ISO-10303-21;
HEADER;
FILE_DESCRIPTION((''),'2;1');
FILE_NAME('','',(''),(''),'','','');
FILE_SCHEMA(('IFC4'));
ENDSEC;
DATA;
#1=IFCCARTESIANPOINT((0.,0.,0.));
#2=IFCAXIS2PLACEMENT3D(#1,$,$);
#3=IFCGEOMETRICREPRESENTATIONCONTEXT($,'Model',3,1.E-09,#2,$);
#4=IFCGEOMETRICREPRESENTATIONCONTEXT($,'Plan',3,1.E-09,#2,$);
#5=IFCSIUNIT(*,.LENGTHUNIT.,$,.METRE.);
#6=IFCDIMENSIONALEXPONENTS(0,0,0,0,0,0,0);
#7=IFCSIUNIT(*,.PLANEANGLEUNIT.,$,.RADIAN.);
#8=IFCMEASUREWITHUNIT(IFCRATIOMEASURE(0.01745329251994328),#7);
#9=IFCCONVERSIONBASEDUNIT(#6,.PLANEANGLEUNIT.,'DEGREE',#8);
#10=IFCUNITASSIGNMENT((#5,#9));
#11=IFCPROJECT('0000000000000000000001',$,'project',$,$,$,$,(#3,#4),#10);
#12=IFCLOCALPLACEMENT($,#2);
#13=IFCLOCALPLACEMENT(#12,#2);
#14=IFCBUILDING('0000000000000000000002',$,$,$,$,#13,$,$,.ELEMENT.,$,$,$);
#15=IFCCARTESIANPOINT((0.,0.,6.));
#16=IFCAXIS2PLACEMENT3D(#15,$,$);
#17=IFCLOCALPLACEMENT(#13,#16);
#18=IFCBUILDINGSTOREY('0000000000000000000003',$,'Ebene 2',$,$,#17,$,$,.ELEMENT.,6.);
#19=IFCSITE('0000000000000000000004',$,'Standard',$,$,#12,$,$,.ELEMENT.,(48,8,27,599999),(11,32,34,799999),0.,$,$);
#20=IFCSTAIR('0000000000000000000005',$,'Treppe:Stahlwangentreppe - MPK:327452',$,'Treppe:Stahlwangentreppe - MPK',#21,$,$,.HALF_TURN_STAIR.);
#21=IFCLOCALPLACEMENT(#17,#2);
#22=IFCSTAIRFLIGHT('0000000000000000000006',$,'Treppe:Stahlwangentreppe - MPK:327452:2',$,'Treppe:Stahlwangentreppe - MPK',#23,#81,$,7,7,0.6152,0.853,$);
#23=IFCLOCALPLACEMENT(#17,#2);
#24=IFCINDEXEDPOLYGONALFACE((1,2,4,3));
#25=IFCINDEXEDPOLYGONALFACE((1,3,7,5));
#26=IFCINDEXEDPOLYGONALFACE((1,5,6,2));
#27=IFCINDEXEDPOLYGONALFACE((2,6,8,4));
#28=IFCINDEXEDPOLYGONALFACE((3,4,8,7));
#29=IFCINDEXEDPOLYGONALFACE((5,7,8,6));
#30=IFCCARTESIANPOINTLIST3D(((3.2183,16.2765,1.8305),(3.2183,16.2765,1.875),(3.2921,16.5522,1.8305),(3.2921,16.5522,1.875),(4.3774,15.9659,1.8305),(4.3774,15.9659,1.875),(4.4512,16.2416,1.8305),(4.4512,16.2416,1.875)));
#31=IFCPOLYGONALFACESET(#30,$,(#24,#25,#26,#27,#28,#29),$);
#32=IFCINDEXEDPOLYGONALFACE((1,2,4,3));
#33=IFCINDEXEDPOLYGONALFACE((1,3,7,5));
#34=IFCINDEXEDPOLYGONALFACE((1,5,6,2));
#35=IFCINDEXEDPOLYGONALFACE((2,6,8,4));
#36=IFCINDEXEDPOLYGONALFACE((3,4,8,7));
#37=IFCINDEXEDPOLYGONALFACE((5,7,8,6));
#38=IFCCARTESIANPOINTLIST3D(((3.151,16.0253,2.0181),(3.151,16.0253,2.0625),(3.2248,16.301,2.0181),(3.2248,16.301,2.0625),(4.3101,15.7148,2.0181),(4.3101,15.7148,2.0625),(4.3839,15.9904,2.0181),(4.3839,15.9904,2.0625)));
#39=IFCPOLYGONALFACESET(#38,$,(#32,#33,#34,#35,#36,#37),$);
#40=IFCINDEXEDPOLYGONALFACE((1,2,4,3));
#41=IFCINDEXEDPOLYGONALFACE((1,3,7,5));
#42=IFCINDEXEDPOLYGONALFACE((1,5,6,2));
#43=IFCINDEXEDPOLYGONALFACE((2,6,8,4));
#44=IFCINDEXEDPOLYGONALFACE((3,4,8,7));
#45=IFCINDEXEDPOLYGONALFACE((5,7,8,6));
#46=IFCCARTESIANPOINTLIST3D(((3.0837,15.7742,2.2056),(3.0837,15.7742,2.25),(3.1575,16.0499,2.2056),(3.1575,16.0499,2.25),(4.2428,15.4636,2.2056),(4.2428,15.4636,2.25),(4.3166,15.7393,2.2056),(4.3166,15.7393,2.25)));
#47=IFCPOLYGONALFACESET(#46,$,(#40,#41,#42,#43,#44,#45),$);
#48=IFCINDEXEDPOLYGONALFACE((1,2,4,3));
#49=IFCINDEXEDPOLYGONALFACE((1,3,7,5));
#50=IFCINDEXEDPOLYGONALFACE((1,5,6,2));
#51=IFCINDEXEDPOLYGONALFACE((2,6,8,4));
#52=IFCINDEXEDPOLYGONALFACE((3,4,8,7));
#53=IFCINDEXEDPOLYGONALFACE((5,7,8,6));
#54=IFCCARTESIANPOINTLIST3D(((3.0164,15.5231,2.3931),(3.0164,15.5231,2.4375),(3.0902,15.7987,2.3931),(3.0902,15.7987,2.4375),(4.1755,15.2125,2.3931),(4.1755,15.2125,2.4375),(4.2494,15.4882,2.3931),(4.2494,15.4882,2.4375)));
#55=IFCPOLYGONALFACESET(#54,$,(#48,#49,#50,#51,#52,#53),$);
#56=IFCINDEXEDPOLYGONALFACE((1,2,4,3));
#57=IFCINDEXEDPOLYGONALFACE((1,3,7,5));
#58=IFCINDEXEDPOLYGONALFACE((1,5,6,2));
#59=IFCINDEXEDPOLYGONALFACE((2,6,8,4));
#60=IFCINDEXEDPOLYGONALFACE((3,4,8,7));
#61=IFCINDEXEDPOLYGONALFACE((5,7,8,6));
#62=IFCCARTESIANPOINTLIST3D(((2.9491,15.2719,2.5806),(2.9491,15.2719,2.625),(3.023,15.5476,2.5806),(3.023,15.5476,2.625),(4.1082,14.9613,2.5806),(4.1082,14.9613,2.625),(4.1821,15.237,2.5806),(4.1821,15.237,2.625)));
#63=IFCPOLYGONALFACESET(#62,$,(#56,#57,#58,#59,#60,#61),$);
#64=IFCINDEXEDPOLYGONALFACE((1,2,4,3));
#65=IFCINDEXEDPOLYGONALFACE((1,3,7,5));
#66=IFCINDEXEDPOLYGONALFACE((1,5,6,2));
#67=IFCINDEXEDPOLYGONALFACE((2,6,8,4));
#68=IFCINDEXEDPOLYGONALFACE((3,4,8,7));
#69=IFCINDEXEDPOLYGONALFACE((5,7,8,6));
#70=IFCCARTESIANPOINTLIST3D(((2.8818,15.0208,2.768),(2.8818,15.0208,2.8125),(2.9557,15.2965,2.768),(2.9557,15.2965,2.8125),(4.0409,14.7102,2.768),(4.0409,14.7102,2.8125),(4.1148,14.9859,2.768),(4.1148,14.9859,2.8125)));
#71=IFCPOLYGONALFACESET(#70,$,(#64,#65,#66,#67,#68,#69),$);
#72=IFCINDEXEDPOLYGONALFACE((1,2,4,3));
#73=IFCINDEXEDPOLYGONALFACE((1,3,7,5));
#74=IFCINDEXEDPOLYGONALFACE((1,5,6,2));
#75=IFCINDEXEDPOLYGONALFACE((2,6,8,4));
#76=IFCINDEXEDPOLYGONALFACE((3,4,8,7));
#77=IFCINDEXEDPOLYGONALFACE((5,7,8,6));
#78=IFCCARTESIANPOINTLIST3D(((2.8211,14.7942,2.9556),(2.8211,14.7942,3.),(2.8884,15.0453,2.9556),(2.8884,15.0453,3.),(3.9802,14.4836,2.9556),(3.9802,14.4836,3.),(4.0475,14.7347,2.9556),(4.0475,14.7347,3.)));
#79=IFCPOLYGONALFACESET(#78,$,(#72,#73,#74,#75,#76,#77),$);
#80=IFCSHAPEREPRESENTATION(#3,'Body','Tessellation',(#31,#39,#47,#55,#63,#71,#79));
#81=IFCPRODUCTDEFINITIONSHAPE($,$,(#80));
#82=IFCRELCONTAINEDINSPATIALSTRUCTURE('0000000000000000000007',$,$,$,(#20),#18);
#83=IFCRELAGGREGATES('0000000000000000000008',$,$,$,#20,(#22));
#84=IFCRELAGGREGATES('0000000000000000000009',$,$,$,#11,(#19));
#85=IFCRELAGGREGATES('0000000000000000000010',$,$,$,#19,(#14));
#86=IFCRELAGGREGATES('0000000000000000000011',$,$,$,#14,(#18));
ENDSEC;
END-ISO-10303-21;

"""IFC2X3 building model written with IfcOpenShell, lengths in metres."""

from ifc_helpers import new_model, entity, si_unit, converted_unit, frame, origin, origin_2d_with_axis, place, context, project, spatial, rectangle, extrude, element, aggregate, save


model = new_model("IFC2X3")

# Units and contexts
model_context = context("Model", 3, precision=1e-09, world=origin())
plan_context = context("Plan", 3, precision=1e-09, world=origin())
ifc_project = project(units=[si_unit("LENGTHUNIT", "METRE"), converted_unit("PLANEANGLEUNIT", "DEGREE", entity("IfcRatioMeasure", 0.01745329251994328), si_unit("PLANEANGLEUNIT", "RADIAN"), dimensions=[0, 0, 0, 0, 0, 0, 0])], contexts=[model_context, plan_context])

# Site, building, storey
site_placement = place(None, origin())
site = spatial("IfcSite", under=ifc_project, at=site_placement, Name="Standard", CompositionType="ELEMENT", RefLatitude=(48, 8, 27, 599999), RefLongitude=(11, 32, 34, 799999), RefElevation=0.0)
building_placement = place(site_placement, origin())
building = spatial("IfcBuilding", under=site, at=building_placement, CompositionType="ELEMENT")
storey_placement = place(building_placement, frame((0.0, 0.0, 6.0)))
storey = spatial("IfcBuildingStorey", under=building, at=storey_placement, Name="Ebene 2", CompositionType="ELEMENT", Elevation=6.0)

# Stair
stair_placement = place(storey_placement, origin())
stair = element("IfcStair", 1, at=stair_placement, inside=storey, Name="Treppe:Stahlwangentreppe - MPK:327452", ObjectType="Treppe:Stahlwangentreppe - MPK", ShapeType="HALF_TURN_STAIR")

# Stair flight
stair_flight_1_placement = place(storey_placement, origin())
stair_flight_1 = element("IfcStairFlight", 2, at=stair_flight_1_placement, Name="Treppe:Stahlwangentreppe - MPK:327452:2", ObjectType="Treppe:Stahlwangentreppe - MPK", NumberOfRiser=7, NumberOfTreads=7, RiserHeight=0.6152, TreadLength=0.853, context=model_context, shape_type="SweptSolid", body=[
    extrude(rectangle(XDim=0.2854, YDim=1.2, at=origin_2d_with_axis()), frame((3.8347, 16.259, 1.8305), z_axis=(0.0, 0.0, 1.0), x_axis=(0.258819, 0.965926, 0.0)), (0.0, 0.0, 1.0), 0.0444),
    extrude(rectangle(XDim=0.2854, YDim=1.2, at=origin_2d_with_axis()), frame((3.7675, 16.0079, 2.0181), z_axis=(0.0, 0.0, 1.0), x_axis=(0.258819, 0.965926, 0.0)), (0.0, 0.0, 1.0), 0.0444),
    extrude(rectangle(XDim=0.2854, YDim=1.2, at=origin_2d_with_axis()), frame((3.7002, 15.7568, 2.2056), z_axis=(0.0, 0.0, 1.0), x_axis=(0.258819, 0.965926, 0.0)), (0.0, 0.0, 1.0), 0.0444),
    extrude(rectangle(XDim=0.2854, YDim=1.2, at=origin_2d_with_axis()), frame((3.6329, 15.5056, 2.3931), z_axis=(0.0, 0.0, 1.0), x_axis=(0.258819, 0.965926, 0.0)), (0.0, 0.0, 1.0), 0.0444),
    extrude(rectangle(XDim=0.2854, YDim=1.2, at=origin_2d_with_axis()), frame((3.5656, 15.2545, 2.5806), z_axis=(0.0, 0.0, 1.0), x_axis=(0.258819, 0.965926, 0.0)), (0.0, 0.0, 1.0), 0.0445),
    extrude(rectangle(XDim=0.2854, YDim=1.2, at=origin_2d_with_axis()), frame((3.4983, 15.0033, 2.768), z_axis=(0.0, 0.0, 1.0), x_axis=(0.258819, 0.965926, 0.0)), (0.0, 0.0, 1.0), 0.0445),
    extrude(rectangle(XDim=0.26, YDim=1.2, at=origin_2d_with_axis()), frame((3.4343, 14.7645, 2.9556), z_axis=(0.0, 0.0, 1.0), x_axis=(0.258819, 0.965926, 0.0)), (0.0, 0.0, 1.0), 0.0445),
])
aggregate(stair, [stair_flight_1])

save(model, "model.ifc")
